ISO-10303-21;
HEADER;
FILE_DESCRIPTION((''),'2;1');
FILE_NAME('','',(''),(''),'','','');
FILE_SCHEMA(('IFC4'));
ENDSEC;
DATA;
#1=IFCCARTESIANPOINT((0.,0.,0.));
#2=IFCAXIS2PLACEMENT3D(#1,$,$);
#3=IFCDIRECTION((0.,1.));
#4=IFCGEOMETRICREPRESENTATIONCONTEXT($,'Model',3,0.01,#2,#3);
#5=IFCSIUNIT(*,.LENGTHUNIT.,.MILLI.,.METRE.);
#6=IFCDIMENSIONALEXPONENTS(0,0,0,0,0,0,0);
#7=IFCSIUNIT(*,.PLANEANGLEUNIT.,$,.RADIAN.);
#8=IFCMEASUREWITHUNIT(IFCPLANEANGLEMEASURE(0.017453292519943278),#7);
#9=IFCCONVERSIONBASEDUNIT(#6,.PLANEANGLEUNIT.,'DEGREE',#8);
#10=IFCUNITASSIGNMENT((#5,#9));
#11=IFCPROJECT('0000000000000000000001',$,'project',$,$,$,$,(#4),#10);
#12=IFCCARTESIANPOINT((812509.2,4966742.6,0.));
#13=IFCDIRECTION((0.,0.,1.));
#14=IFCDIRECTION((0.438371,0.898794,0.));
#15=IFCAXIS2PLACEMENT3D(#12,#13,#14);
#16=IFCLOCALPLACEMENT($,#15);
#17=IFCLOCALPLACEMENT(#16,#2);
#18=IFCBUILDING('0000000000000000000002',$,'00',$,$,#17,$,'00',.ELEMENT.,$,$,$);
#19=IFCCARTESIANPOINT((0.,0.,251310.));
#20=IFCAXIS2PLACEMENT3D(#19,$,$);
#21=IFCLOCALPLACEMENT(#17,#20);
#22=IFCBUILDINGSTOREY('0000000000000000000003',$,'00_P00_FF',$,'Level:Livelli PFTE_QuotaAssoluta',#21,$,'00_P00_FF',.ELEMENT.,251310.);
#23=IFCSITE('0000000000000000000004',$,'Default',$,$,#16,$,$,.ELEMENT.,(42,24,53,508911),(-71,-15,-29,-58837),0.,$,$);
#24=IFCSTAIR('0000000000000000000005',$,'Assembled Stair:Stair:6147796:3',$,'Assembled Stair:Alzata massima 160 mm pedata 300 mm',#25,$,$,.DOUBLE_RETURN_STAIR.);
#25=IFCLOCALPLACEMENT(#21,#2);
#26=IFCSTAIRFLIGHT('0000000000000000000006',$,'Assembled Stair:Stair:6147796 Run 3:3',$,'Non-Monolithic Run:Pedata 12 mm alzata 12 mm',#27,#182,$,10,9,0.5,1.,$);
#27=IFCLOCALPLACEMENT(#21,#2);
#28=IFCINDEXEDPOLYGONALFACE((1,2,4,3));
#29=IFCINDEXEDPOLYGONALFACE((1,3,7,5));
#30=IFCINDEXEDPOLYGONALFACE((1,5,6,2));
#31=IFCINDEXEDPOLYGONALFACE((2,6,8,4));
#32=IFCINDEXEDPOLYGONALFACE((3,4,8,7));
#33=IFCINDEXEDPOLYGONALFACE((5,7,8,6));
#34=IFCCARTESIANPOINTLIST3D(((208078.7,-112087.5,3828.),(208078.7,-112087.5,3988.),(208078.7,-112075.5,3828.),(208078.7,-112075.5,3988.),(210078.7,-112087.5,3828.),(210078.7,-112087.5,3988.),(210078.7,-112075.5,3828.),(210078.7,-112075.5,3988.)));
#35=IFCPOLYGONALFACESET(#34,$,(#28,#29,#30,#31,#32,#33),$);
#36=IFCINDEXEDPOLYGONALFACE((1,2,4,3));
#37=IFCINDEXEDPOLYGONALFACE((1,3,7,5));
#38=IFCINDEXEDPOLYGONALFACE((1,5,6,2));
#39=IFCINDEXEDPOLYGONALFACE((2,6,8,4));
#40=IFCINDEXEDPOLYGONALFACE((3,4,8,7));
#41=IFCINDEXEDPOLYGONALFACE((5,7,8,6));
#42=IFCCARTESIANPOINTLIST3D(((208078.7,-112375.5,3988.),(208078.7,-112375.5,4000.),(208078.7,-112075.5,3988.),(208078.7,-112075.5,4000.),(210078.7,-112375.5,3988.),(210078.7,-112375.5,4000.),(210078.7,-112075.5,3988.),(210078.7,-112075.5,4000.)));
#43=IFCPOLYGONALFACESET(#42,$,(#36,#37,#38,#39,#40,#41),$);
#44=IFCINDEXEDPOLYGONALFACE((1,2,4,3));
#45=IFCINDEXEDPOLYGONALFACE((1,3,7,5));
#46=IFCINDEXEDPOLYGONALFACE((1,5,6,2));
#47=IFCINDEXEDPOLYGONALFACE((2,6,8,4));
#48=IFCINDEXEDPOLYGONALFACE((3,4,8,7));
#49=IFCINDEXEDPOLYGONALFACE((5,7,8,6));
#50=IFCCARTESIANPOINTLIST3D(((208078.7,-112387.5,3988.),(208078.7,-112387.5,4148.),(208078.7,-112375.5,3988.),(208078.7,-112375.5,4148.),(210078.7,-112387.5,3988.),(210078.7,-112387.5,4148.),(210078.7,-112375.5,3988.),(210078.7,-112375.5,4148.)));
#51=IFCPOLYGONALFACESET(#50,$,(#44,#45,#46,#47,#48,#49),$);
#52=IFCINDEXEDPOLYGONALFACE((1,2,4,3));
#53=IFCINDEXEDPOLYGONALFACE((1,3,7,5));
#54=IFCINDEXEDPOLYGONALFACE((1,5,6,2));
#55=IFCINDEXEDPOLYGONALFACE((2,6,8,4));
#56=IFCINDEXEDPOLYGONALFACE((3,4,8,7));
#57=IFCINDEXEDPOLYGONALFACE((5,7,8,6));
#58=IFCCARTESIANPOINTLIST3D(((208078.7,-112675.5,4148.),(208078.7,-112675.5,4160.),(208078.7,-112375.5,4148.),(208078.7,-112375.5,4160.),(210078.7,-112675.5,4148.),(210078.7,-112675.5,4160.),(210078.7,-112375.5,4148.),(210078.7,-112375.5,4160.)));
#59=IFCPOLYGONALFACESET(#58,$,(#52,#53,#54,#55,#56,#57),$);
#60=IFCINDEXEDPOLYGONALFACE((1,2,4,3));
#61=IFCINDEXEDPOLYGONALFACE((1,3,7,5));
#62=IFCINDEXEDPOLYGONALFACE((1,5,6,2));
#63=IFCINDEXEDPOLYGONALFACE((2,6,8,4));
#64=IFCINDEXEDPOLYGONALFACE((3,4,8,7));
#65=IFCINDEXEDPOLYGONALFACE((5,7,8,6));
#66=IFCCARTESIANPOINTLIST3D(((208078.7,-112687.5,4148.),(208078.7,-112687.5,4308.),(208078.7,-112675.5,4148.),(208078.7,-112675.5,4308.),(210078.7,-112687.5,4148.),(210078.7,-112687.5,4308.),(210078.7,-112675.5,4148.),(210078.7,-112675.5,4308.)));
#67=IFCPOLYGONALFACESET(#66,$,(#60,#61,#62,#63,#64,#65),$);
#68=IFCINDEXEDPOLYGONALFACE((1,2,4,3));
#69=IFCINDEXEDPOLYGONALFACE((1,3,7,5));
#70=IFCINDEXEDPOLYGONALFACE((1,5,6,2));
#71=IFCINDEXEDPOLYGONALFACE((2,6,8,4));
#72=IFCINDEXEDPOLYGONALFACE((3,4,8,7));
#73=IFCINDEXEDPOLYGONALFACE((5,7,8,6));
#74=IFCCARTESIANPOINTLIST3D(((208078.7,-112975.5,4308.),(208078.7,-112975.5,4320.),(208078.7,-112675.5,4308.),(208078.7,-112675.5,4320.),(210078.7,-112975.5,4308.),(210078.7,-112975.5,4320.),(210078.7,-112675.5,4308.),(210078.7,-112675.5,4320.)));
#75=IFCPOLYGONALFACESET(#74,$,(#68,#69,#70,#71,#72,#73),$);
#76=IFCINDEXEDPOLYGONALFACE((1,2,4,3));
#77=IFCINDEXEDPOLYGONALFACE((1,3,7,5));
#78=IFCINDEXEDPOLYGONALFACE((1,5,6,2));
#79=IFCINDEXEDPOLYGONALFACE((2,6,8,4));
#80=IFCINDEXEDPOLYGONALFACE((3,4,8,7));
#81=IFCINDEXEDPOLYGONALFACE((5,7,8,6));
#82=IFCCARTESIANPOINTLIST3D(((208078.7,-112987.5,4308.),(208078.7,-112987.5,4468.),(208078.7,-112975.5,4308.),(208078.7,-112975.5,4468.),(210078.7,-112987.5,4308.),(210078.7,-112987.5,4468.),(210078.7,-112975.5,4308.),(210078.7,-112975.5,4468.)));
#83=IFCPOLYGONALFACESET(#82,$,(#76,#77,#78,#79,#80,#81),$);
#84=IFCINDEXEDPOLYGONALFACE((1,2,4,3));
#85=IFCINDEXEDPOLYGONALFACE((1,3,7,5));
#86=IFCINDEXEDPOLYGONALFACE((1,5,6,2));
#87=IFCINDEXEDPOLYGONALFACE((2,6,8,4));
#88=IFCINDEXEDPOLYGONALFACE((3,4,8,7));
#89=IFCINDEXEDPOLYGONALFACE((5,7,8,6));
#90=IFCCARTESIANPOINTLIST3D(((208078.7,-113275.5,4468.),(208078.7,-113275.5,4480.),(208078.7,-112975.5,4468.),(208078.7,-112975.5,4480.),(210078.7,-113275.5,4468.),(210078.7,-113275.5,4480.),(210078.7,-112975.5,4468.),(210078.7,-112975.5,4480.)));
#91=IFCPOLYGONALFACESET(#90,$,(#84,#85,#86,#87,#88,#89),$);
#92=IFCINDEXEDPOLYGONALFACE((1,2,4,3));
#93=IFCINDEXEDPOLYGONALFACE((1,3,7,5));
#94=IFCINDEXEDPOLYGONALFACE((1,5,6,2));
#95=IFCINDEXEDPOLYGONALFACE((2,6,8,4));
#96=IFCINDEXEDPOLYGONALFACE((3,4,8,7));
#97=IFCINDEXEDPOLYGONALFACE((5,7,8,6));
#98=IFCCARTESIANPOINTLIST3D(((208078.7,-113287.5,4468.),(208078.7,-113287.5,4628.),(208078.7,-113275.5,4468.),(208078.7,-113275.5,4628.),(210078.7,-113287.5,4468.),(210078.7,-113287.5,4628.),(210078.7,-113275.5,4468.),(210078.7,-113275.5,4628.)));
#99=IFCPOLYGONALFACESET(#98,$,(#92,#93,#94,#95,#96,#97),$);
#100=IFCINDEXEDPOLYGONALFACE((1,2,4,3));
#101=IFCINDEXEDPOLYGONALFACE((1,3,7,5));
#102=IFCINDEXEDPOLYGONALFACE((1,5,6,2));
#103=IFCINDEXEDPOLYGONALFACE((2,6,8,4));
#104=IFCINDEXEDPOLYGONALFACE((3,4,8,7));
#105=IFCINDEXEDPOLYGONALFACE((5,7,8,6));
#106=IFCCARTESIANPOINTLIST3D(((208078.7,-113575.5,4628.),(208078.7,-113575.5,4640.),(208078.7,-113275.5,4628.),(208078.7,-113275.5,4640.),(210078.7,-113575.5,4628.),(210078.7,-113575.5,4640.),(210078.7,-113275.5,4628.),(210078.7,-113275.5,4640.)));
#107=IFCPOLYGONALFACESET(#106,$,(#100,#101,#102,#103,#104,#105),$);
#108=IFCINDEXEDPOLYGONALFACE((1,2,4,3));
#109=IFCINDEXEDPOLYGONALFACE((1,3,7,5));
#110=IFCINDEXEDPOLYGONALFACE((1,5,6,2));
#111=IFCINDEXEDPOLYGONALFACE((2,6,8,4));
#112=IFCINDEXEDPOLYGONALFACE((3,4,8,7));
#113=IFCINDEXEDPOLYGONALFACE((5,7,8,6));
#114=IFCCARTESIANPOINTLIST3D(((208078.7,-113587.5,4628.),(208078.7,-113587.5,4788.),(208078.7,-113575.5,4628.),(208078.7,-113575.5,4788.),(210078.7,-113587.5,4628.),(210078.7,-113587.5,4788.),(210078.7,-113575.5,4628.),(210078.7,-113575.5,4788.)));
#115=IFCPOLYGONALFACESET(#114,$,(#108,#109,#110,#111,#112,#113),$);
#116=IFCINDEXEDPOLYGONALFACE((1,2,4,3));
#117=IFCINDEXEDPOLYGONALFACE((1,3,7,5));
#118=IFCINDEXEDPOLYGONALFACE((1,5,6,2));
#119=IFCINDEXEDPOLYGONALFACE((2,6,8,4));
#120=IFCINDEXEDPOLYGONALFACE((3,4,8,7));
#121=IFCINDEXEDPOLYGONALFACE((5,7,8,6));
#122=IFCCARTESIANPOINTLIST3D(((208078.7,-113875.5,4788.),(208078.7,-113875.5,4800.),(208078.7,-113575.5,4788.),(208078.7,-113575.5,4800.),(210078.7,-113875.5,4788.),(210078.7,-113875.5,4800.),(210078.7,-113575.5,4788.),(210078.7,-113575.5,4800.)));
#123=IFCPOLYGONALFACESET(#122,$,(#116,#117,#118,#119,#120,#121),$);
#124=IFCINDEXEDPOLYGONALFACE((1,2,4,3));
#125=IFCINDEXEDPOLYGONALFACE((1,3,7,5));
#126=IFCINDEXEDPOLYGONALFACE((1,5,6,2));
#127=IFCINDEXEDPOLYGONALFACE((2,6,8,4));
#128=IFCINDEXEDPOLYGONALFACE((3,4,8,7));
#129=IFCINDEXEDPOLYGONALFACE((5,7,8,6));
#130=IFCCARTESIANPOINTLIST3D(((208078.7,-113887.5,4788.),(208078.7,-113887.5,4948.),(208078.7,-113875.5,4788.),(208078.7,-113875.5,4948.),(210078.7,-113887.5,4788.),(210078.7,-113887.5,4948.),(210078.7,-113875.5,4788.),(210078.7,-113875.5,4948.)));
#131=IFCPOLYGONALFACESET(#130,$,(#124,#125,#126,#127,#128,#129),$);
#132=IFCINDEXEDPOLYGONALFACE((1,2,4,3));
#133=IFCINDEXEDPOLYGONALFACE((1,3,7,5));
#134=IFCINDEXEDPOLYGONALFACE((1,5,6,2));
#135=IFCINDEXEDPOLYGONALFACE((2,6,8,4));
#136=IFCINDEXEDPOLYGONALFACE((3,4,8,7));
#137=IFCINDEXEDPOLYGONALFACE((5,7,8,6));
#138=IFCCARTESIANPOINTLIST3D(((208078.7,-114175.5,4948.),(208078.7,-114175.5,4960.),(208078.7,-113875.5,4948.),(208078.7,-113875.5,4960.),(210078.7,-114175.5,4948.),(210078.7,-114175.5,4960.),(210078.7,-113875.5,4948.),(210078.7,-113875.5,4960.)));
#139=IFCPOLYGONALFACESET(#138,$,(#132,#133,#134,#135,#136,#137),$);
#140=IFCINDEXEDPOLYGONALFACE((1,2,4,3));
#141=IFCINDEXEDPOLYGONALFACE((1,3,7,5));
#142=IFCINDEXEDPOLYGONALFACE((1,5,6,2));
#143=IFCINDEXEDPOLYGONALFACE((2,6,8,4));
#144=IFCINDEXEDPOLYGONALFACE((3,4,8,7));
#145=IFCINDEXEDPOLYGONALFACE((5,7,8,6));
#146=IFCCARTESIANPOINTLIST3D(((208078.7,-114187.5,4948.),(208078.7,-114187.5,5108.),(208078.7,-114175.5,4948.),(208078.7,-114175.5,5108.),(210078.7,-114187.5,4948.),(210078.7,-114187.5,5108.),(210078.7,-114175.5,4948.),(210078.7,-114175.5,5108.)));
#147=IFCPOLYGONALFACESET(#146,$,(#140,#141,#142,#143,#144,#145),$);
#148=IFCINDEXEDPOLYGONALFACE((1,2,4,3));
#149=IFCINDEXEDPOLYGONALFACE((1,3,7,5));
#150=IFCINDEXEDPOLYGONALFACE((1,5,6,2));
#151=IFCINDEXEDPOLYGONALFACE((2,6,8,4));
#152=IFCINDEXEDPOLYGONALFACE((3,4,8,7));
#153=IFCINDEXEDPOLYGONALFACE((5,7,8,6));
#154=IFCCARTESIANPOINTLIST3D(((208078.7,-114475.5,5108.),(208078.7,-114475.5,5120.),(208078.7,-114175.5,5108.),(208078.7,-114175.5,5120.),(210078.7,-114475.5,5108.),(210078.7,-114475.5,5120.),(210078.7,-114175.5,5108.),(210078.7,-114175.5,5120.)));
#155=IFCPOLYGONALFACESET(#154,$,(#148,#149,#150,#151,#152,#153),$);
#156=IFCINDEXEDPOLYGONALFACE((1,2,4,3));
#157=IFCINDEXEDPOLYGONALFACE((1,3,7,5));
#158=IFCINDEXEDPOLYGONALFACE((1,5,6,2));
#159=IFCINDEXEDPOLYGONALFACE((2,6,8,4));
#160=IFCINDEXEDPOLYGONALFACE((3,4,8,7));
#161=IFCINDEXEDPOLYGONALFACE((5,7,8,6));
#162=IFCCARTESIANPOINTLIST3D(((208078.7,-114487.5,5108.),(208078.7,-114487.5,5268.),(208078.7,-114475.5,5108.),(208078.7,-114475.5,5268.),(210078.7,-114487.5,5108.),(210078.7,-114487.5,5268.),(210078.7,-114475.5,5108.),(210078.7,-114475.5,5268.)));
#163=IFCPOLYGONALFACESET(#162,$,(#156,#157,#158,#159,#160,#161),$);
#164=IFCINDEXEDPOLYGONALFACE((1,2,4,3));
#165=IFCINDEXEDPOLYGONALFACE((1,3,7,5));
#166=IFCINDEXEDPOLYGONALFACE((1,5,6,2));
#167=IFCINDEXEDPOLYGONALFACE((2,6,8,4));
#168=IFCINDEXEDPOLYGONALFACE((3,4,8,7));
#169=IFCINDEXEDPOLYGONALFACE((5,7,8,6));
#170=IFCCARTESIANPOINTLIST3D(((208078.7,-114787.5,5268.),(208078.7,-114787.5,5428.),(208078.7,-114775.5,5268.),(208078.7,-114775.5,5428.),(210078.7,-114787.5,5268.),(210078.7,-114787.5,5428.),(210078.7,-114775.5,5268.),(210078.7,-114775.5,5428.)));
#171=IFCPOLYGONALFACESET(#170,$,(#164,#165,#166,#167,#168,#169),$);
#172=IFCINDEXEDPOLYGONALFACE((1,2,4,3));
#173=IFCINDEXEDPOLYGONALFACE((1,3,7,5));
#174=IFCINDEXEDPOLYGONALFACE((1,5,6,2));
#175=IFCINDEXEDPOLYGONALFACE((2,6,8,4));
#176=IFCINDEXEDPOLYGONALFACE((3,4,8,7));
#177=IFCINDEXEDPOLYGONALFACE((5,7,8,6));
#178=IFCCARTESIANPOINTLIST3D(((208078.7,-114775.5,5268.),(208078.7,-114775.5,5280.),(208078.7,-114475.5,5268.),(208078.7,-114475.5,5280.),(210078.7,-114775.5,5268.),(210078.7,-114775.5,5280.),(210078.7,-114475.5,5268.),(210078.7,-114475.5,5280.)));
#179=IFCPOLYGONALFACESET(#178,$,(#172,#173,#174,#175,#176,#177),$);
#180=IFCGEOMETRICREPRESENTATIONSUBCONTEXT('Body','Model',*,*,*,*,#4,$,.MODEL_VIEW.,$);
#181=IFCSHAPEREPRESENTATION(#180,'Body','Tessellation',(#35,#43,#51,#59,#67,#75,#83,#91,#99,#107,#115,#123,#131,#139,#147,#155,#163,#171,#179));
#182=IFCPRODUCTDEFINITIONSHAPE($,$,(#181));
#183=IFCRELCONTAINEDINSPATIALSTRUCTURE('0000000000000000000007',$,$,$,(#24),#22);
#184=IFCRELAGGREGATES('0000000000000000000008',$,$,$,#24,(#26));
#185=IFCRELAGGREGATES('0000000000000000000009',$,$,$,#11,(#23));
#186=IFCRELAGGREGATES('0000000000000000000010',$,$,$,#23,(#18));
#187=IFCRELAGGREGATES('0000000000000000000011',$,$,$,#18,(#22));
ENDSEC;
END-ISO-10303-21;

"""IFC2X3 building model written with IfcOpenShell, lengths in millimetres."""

from ifc_helpers import new_model, entity, si_unit, converted_unit, direction, frame, frame_2d, origin, origin_2d_with_axis, place, context, subcontext, project, spatial, rectangle, extrude, element, aggregate, save


model = new_model("IFC2X3")

# Units and contexts
model_context = context("Model", 3, precision=0.01, world=origin(), true_north=direction((0.0, 1.0)))
body_context = subcontext(model_context, "Body", "Model", "MODEL_VIEW")
ifc_project = project(units=[si_unit("LENGTHUNIT", "METRE", prefix="MILLI"), converted_unit("PLANEANGLEUNIT", "DEGREE", entity("IfcPlaneAngleMeasure", 0.017453292519943278), si_unit("PLANEANGLEUNIT", "RADIAN"), dimensions=[0, 0, 0, 0, 0, 0, 0])], contexts=[model_context])

# Site, building, storey
site_placement = place(None, frame((812509.2, 4966742.6, 0.0), z_axis=(0.0, 0.0, 1.0), x_axis=(0.438371, 0.898794, 0.0)))
site = spatial("IfcSite", under=ifc_project, at=site_placement, Name="Default", CompositionType="ELEMENT", RefLatitude=(42, 24, 53, 508911), RefLongitude=(-71, -15, -29, -58837), RefElevation=0.0)
building_placement = place(site_placement, origin())
building = spatial("IfcBuilding", under=site, at=building_placement, Name="00", LongName="00", CompositionType="ELEMENT")
storey_placement = place(building_placement, frame((0.0, 0.0, 251310.0)))
storey = spatial("IfcBuildingStorey", under=building, at=storey_placement, Name="00_P00_FF", ObjectType="Level:Livelli PFTE_QuotaAssoluta", LongName="00_P00_FF", CompositionType="ELEMENT", Elevation=251310.0)

# Stair
stair_1_placement = place(storey_placement, origin())
stair_1 = element("IfcStair", 1, at=stair_1_placement, inside=storey, Name="Assembled Stair:Stair:6147796:3", ObjectType="Assembled Stair:Alzata massima 160 mm pedata 300 mm", ShapeType="DOUBLE_RETURN_STAIR")

# Stair flight
stair_flight_1_placement = place(stair_1_placement, origin())
stair_flight_1 = element("IfcStairFlight", 2, at=stair_flight_1_placement, Name="Assembled Stair:Stair:6147796 Run 3:3", ObjectType="Non-Monolithic Run:Pedata 12 mm alzata 12 mm", NumberOfRiser=10, NumberOfTreads=9, RiserHeight=0.5, TreadLength=1.0, context=body_context, shape_type="SweptSolid", body=[
    extrude(rectangle(XDim=2000.0, YDim=12.0, at=origin_2d_with_axis()), frame((209078.7, -112081.5, 3828.0)), (0.0, 0.0, 1.0), 160.0),
    extrude(rectangle(XDim=300.0, YDim=2000.0, at=origin_2d_with_axis()), frame((209078.7, -112225.5, 3988.0), z_axis=(0.0, 0.0, 1.0), x_axis=(0.0, 1.0, 0.0)), (0.0, 0.0, 1.0), 12.0),
    extrude(rectangle(XDim=2000.0, YDim=12.0, at=origin_2d_with_axis()), frame((209078.7, -112381.5, 3988.0)), (0.0, 0.0, 1.0), 160.0),
    extrude(rectangle(XDim=300.0, YDim=2000.0, at=frame_2d((0.0, 0.0), x_axis=(1.0, 0.0))), frame((209078.7, -112525.5, 4148.0), z_axis=(0.0, 0.0, 1.0), x_axis=(0.0, 1.0, 0.0)), (0.0, 0.0, 1.0), 12.0),
    extrude(rectangle(XDim=2000.0, YDim=12.0, at=frame_2d((0.0, 0.0), x_axis=(1.0, 0.0))), frame((209078.7, -112681.5, 4148.0)), (0.0, 0.0, 1.0), 160.0),
    extrude(rectangle(XDim=300.0, YDim=2000.0, at=frame_2d((0.0, 0.0), x_axis=(1.0, 0.0))), frame((209078.7, -112825.5, 4308.0), z_axis=(0.0, 0.0, 1.0), x_axis=(0.0, 1.0, 0.0)), (0.0, 0.0, 1.0), 12.0),
    extrude(rectangle(XDim=2000.0, YDim=12.0, at=frame_2d((0.0, 0.0), x_axis=(1.0, 0.0))), frame((209078.7, -112981.5, 4308.0)), (0.0, 0.0, 1.0), 160.0),
    extrude(rectangle(XDim=300.0, YDim=2000.0, at=frame_2d((0.0, 0.0), x_axis=(1.0, 0.0))), frame((209078.7, -113125.5, 4468.0), z_axis=(0.0, 0.0, 1.0), x_axis=(0.0, 1.0, 0.0)), (0.0, 0.0, 1.0), 12.0),
    extrude(rectangle(XDim=2000.0, YDim=12.0, at=frame_2d((0.0, 0.0), x_axis=(1.0, 0.0))), frame((209078.7, -113281.5, 4468.0)), (0.0, 0.0, 1.0), 160.0),
    extrude(rectangle(XDim=300.0, YDim=2000.0, at=frame_2d((0.0, 0.0), x_axis=(1.0, 0.0))), frame((209078.7, -113425.5, 4628.0), z_axis=(0.0, 0.0, 1.0), x_axis=(0.0, 1.0, 0.0)), (0.0, 0.0, 1.0), 12.0),
    extrude(rectangle(XDim=2000.0, YDim=12.0, at=frame_2d((0.0, 0.0), x_axis=(1.0, 0.0))), frame((209078.7, -113581.5, 4628.0)), (0.0, 0.0, 1.0), 160.0),
    extrude(rectangle(XDim=300.0, YDim=2000.0, at=frame_2d((0.0, 0.0), x_axis=(1.0, 0.0))), frame((209078.7, -113725.5, 4788.0), z_axis=(0.0, 0.0, 1.0), x_axis=(0.0, 1.0, 0.0)), (0.0, 0.0, 1.0), 12.0),
    extrude(rectangle(XDim=2000.0, YDim=12.0, at=origin_2d_with_axis()), frame((209078.7, -113881.5, 4788.0)), (0.0, 0.0, 1.0), 160.0),
    extrude(rectangle(XDim=300.0, YDim=2000.0, at=frame_2d((0.0, 0.0), x_axis=(1.0, 0.0))), frame((209078.7, -114025.5, 4948.0), z_axis=(0.0, 0.0, 1.0), x_axis=(0.0, 1.0, 0.0)), (0.0, 0.0, 1.0), 12.0),
    extrude(rectangle(XDim=2000.0, YDim=12.0, at=origin_2d_with_axis()), frame((209078.7, -114181.5, 4948.0)), (0.0, 0.0, 1.0), 160.0),
    extrude(rectangle(XDim=300.0, YDim=2000.0, at=frame_2d((0.0, 0.0), x_axis=(1.0, 0.0))), frame((209078.7, -114325.5, 5108.0), z_axis=(0.0, 0.0, 1.0), x_axis=(0.0, 1.0, 0.0)), (0.0, 0.0, 1.0), 12.0),
    extrude(rectangle(XDim=2000.0, YDim=12.0, at=origin_2d_with_axis()), frame((209078.7, -114481.5, 5108.0)), (0.0, 0.0, 1.0), 160.0),
    extrude(rectangle(XDim=2000.0, YDim=12.0, at=origin_2d_with_axis()), frame((209078.7, -114781.5, 5268.0)), (0.0, 0.0, 1.0), 160.0),
    extrude(rectangle(XDim=300.0, YDim=2000.0, at=frame_2d((0.0, 0.0), x_axis=(1.0, 0.0))), frame((209078.7, -114625.5, 5268.0), z_axis=(0.0, 0.0, 1.0), x_axis=(0.0, 1.0, 0.0)), (0.0, 0.0, 1.0), 12.0),
])
aggregate(stair_1, [stair_flight_1])

save(model, "model.ifc")
